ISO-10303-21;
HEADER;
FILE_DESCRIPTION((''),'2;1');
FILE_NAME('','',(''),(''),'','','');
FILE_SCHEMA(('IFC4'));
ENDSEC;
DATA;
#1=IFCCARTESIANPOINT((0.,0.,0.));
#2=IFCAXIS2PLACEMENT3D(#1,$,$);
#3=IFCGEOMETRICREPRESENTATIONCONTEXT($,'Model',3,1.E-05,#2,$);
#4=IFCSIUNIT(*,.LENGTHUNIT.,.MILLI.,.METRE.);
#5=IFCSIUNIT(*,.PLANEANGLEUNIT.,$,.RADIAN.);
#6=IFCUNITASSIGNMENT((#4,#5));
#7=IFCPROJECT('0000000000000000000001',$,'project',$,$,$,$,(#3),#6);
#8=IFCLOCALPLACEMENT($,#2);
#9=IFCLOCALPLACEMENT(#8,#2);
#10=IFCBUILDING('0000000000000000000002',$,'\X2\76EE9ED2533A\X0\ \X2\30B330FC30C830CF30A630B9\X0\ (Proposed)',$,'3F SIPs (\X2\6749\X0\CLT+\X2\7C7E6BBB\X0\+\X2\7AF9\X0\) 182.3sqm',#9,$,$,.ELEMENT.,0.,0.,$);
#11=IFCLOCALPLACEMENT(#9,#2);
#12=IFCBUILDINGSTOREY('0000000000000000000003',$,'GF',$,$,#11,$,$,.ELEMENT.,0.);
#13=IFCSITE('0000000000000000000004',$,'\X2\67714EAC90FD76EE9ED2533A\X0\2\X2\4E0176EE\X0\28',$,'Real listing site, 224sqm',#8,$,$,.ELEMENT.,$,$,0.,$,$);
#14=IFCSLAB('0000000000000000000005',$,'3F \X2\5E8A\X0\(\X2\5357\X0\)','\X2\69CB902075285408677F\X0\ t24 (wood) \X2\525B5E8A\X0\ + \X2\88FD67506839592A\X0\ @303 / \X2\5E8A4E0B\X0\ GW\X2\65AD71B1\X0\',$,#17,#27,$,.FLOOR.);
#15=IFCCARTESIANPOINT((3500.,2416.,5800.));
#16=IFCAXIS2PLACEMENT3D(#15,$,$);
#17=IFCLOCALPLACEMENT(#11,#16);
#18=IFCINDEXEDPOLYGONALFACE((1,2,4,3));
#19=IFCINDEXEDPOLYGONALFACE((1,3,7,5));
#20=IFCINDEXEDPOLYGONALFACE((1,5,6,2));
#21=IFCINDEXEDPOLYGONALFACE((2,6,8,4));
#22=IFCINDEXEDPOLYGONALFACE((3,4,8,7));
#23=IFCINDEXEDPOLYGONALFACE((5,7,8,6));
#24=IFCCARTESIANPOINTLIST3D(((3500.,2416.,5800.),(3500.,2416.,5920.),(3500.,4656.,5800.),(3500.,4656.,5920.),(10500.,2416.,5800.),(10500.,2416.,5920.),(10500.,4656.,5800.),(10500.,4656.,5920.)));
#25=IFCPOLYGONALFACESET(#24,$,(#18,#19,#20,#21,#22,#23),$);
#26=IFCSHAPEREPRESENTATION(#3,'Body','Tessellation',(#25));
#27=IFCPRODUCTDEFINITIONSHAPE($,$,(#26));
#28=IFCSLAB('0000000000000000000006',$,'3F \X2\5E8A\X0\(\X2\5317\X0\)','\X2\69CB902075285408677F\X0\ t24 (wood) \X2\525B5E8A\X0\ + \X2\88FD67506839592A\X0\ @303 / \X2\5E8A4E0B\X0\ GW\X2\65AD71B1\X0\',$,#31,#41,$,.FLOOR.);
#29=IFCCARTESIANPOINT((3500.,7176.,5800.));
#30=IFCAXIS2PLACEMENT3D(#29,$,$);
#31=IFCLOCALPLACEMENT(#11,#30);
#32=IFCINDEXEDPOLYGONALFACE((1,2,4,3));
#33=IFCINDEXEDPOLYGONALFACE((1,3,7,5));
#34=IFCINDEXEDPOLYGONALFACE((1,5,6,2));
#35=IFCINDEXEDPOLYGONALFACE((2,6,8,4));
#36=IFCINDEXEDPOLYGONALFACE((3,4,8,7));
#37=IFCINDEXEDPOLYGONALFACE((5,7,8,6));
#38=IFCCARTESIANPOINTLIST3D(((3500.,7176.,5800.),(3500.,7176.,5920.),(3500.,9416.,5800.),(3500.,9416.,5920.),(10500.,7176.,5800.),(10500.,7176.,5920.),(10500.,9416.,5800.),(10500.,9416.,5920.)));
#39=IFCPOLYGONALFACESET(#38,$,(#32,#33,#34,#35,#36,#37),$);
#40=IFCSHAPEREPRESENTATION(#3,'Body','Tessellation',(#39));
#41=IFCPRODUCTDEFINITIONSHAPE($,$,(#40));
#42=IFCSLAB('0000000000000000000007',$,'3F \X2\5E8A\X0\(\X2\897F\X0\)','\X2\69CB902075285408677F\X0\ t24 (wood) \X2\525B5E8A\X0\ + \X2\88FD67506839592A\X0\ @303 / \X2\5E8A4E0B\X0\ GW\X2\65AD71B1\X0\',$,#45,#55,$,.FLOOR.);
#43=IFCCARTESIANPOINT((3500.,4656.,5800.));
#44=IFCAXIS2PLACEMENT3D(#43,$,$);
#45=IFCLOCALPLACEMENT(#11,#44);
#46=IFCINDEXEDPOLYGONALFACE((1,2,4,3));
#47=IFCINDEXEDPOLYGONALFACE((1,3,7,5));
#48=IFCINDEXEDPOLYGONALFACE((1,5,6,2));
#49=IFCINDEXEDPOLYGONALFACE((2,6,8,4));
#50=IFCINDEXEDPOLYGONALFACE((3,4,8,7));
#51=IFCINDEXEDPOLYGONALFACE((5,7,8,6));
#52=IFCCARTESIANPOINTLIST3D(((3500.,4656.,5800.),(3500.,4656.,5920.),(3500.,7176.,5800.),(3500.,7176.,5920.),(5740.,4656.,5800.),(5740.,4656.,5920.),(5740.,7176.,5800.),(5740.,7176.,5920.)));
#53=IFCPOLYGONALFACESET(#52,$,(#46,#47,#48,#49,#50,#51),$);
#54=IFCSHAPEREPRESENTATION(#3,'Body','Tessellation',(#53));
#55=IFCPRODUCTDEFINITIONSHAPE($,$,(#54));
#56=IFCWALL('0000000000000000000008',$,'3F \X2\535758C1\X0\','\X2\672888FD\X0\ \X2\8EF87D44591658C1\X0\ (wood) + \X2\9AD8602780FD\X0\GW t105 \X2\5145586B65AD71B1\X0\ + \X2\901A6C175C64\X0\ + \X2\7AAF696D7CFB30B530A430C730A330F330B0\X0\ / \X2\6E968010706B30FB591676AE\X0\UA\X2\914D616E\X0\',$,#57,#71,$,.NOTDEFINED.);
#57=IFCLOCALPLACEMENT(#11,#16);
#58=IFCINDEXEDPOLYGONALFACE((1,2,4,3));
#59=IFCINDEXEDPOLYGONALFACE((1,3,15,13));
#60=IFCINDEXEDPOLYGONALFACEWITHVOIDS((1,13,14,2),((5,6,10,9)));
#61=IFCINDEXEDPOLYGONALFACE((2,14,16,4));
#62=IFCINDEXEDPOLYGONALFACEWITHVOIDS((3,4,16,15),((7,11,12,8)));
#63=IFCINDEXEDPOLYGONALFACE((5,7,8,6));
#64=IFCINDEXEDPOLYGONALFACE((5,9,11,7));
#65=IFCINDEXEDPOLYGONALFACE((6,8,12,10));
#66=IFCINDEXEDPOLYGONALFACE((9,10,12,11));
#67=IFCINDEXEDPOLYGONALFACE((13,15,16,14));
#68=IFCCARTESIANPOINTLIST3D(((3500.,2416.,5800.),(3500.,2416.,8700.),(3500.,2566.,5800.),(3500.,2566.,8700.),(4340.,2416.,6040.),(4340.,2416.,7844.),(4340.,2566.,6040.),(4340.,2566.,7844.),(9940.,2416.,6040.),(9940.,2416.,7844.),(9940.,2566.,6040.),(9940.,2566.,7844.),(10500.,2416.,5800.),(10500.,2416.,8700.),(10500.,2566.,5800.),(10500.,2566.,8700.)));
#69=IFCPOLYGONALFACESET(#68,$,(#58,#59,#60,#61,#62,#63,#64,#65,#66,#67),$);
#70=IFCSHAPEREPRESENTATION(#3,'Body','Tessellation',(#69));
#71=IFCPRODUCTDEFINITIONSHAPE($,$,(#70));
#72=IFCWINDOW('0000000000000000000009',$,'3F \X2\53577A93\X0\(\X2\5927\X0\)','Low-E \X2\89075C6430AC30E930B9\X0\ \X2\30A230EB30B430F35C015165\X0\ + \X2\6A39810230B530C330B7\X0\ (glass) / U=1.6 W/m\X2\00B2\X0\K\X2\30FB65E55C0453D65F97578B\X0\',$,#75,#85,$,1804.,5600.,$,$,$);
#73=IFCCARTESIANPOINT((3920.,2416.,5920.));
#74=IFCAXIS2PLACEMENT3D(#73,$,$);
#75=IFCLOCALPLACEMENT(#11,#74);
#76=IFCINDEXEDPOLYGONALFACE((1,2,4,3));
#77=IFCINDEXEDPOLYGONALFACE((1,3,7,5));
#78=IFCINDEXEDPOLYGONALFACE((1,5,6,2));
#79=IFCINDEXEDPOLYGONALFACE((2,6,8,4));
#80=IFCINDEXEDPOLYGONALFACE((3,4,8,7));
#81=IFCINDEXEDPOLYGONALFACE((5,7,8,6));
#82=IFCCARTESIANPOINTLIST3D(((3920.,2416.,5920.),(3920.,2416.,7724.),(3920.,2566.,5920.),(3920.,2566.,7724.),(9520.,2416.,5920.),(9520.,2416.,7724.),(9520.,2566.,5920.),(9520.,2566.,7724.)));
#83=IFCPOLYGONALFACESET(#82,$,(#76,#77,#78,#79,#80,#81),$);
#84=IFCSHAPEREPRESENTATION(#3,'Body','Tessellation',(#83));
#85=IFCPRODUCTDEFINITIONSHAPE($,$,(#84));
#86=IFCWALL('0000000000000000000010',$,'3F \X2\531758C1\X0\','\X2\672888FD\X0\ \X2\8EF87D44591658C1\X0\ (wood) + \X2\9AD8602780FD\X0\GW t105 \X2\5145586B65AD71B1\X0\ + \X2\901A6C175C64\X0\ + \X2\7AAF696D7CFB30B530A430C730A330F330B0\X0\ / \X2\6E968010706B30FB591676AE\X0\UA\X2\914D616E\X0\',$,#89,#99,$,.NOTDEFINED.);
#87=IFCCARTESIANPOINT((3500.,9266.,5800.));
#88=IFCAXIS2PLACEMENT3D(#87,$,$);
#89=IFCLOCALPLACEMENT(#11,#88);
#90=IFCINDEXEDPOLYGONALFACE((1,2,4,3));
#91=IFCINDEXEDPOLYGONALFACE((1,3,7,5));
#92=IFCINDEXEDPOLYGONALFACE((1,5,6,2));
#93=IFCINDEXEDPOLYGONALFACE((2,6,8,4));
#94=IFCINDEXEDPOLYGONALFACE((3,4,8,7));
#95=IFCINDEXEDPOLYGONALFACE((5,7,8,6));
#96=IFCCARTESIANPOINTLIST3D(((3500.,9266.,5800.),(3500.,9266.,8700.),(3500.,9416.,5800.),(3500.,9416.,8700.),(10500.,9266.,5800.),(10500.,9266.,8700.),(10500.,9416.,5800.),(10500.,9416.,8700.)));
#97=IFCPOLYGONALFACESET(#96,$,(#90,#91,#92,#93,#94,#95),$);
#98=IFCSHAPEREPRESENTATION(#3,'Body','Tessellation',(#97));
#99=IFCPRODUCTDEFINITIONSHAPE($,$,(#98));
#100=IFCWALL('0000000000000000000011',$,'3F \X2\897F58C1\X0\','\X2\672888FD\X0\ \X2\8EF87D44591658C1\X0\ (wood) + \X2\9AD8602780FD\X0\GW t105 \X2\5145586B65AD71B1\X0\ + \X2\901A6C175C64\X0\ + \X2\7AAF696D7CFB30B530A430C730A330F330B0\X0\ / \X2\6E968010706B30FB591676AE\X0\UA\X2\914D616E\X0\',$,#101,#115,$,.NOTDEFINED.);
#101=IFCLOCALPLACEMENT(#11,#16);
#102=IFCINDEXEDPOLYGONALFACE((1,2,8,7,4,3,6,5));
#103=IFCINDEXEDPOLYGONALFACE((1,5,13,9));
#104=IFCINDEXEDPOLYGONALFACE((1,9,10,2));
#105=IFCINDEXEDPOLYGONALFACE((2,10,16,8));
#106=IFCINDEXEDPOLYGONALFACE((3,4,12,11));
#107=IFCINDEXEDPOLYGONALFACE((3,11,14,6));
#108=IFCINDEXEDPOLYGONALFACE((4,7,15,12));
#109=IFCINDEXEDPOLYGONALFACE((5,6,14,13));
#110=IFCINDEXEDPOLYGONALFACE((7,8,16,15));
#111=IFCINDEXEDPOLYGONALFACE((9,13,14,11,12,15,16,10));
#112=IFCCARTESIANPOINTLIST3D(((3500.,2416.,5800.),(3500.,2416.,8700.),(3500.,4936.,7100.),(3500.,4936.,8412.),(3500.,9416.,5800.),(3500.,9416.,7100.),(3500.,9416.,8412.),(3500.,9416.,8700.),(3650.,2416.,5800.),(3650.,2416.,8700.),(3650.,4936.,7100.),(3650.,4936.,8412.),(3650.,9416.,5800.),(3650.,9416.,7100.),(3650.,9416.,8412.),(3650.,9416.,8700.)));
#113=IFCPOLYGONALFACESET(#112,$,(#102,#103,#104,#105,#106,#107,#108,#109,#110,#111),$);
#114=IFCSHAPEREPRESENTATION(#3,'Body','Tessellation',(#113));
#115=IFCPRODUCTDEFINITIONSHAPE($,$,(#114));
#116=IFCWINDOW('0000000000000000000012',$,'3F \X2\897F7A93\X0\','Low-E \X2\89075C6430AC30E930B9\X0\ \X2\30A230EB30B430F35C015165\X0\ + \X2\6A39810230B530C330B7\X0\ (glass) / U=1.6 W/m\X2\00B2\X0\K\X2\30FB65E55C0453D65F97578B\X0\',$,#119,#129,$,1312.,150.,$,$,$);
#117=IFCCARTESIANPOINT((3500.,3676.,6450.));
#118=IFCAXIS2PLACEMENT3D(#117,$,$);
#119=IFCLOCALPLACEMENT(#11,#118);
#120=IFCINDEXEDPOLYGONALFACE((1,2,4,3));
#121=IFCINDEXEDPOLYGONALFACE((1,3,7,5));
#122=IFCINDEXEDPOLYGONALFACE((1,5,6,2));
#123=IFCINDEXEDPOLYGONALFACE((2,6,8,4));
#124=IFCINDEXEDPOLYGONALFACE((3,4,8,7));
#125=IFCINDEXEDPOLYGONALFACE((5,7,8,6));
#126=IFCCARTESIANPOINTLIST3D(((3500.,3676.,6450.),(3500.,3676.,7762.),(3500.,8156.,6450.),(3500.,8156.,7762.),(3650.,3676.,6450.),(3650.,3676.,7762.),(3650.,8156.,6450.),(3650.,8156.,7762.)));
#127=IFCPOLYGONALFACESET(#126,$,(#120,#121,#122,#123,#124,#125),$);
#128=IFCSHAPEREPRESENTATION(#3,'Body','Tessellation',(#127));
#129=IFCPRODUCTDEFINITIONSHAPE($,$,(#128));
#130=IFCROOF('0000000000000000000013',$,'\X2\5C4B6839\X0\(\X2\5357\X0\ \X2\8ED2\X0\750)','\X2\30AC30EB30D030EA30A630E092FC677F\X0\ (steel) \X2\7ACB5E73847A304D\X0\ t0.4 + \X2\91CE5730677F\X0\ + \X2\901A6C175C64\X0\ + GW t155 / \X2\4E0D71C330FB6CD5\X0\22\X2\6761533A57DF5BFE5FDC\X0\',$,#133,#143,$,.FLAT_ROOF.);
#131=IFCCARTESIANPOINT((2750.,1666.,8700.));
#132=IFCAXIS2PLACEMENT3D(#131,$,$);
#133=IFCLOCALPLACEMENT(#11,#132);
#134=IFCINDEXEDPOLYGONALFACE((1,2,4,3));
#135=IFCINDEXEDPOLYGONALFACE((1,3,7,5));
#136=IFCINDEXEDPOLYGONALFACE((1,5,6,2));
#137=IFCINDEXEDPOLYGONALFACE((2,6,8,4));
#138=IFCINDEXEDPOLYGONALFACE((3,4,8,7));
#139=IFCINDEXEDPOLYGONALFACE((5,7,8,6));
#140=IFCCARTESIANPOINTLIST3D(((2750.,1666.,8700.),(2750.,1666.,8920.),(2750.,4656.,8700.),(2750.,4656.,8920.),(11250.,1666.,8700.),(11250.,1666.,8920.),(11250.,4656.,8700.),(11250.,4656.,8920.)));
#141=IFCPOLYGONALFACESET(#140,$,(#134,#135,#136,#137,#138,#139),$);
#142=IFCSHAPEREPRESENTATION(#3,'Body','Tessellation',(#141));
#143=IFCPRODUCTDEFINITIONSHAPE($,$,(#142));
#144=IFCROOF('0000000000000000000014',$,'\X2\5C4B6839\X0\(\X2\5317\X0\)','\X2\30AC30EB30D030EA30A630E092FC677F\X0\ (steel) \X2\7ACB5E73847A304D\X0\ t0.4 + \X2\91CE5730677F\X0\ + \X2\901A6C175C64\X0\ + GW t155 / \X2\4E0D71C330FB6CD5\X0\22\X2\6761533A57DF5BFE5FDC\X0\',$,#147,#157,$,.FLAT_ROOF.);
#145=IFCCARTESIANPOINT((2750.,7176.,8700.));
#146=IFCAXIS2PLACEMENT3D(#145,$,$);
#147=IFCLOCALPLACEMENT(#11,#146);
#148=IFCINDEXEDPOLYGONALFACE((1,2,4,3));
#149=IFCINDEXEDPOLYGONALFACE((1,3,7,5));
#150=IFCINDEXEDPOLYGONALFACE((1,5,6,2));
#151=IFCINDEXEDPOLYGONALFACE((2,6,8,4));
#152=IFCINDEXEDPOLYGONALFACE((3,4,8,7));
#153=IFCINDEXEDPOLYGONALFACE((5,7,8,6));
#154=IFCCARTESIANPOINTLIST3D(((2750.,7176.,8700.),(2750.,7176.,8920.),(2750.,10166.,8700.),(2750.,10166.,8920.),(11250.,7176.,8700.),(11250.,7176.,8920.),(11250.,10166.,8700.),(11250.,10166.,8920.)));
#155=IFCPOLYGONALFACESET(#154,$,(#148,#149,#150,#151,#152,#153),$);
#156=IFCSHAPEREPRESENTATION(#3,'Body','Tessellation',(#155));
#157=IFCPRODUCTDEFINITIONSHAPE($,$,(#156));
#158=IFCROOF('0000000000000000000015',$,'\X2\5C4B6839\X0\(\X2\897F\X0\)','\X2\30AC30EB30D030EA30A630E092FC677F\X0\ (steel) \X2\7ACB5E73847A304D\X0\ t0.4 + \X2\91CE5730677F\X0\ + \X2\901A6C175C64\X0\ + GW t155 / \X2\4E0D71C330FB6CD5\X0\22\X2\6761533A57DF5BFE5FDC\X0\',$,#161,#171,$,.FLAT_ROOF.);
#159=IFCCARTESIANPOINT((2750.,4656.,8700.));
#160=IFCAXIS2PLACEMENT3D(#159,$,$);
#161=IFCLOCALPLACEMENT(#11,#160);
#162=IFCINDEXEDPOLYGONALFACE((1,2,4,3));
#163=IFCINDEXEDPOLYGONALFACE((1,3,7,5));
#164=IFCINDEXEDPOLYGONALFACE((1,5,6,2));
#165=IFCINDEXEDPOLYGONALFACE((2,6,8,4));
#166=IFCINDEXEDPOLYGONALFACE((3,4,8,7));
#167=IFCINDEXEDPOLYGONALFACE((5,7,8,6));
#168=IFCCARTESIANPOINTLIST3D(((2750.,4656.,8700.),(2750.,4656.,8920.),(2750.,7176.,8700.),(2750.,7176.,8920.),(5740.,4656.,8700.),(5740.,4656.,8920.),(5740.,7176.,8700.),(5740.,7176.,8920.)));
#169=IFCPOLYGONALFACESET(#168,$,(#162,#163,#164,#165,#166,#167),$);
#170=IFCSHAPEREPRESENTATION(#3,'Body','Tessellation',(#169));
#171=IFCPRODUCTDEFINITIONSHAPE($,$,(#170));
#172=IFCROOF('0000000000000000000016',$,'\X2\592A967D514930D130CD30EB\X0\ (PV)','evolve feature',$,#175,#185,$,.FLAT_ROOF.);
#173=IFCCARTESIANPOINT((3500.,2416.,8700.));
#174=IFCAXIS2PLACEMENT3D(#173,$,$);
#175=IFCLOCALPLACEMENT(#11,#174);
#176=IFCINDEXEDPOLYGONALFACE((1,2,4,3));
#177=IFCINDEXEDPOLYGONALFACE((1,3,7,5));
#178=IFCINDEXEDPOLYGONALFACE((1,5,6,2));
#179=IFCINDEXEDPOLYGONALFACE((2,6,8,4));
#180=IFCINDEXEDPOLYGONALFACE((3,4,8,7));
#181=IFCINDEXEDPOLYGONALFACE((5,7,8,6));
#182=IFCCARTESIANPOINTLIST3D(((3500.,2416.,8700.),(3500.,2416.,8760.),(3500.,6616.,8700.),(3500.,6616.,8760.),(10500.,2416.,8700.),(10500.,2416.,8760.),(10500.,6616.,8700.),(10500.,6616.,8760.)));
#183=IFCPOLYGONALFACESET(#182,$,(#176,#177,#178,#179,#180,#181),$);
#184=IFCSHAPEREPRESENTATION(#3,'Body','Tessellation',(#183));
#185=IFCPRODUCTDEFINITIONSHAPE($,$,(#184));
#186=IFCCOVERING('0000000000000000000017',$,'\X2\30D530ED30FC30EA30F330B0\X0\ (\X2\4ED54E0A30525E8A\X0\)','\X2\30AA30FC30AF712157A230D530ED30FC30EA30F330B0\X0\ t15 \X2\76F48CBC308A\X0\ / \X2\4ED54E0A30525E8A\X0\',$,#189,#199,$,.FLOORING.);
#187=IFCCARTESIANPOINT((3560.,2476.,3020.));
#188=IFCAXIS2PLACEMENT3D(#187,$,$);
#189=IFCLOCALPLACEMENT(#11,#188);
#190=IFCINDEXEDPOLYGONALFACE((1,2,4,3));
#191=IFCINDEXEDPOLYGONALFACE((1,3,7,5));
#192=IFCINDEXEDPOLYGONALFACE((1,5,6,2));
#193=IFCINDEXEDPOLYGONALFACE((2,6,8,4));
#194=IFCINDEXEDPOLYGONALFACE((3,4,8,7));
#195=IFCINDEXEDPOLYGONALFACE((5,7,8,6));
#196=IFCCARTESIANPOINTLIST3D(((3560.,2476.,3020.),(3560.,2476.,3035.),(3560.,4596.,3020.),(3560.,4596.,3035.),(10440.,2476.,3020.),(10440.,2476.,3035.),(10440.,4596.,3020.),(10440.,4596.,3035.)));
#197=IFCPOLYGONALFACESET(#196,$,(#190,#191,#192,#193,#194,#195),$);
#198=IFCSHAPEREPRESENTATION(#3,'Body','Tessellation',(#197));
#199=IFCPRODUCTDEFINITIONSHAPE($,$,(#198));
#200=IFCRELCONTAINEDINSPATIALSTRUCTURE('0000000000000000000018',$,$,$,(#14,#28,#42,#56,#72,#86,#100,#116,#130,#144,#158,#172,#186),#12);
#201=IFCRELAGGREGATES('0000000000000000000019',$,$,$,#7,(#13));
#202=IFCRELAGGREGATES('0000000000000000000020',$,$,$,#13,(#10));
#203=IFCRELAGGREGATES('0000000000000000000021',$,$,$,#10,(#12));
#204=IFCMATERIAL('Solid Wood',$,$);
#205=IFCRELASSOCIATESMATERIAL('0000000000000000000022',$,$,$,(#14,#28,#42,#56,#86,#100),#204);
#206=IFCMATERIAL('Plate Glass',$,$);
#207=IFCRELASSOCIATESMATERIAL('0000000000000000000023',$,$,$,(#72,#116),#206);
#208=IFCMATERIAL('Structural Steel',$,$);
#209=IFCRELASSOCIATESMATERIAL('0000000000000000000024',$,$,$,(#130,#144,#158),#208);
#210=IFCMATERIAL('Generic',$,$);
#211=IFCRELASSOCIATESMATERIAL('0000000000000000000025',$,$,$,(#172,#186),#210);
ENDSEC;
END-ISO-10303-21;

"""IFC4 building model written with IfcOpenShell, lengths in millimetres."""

from ifc_helpers import new_model, si_unit, frame, frame_2d, origin, place, context, project, spatial, rectangle, extrude, material, element, fill, save


model = new_model("IFC4")

# Units and contexts
model_context = context("Model", 3, precision=1e-05, world=origin())
ifc_project = project(units=[si_unit("LENGTHUNIT", "METRE", prefix="MILLI"), si_unit("PLANEANGLEUNIT", "RADIAN")], contexts=[model_context])

# Site, building, storey
site_placement = place(None, origin())
site = spatial("IfcSite", under=ifc_project, at=site_placement, Name="東京都目黒区2丁目28", ObjectType="Real listing site, 224sqm", CompositionType="ELEMENT", RefElevation=0.0)
building_placement = place(site_placement, origin())
building = spatial("IfcBuilding", under=site, at=building_placement, Name="目黒区 コートハウス (Proposed)", ObjectType="3F SIPs (杉CLT+籾殻+竹) 182.3sqm", CompositionType="ELEMENT", ElevationOfRefHeight=0.0, ElevationOfTerrain=0.0)
storey_placement = place(building_placement, origin())
storey = spatial("IfcBuildingStorey", under=building, at=storey_placement, Name="GF", CompositionType="ELEMENT", Elevation=0.0)

# Slabs
ifc_material_1 = material(Name="Solid Wood")
slab_1_placement = place(storey_placement, frame((3500.0, 2416.0, 5800.0)))
element("IfcSlab", 1, at=slab_1_placement, inside=storey, material=ifc_material_1, Name="3F 床(南)", Description="構造用合板 t24 (wood) 剛床 + 製材根太 @303 / 床下 GW断熱", PredefinedType="FLOOR", context=model_context, shape_type="SweptSolid", body=[
    extrude(rectangle(XDim=7000.0, YDim=2240.0, at=frame_2d((3500.0, 1120.0))), frame((3500.0, 2416.0, 5800.0)), (0.0, 0.0, 1.0), 120.0),
])
slab_2_placement = place(storey_placement, frame((3500.0, 7176.0, 5800.0)))
element("IfcSlab", 2, at=slab_2_placement, inside=storey, material=ifc_material_1, Name="3F 床(北)", Description="構造用合板 t24 (wood) 剛床 + 製材根太 @303 / 床下 GW断熱", PredefinedType="FLOOR", context=model_context, shape_type="SweptSolid", body=[
    extrude(rectangle(XDim=7000.0, YDim=2240.0, at=frame_2d((3500.0, 1120.0))), frame((3500.0, 7176.0, 5800.0)), (0.0, 0.0, 1.0), 120.0),
])
slab_3_placement = place(storey_placement, frame((3500.0, 4656.0, 5800.0)))
element("IfcSlab", 3, at=slab_3_placement, inside=storey, material=ifc_material_1, Name="3F 床(西)", Description="構造用合板 t24 (wood) 剛床 + 製材根太 @303 / 床下 GW断熱", PredefinedType="FLOOR", context=model_context, shape_type="SweptSolid", body=[
    extrude(rectangle(XDim=2240.0, YDim=2520.0, at=frame_2d((1120.0, 1260.0))), frame((3500.0, 4656.0, 5800.0)), (0.0, 0.0, 1.0), 120.0),
])

# Wall, opening, window
wall_1_placement = place(storey_placement, frame((3500.0, 2416.0, 5800.0)))
wall_1 = element("IfcWall", 4, at=wall_1_placement, inside=storey, material=ifc_material_1, Name="3F 南壁", Description="木製 軸組外壁 (wood) + 高性能GW t105 充填断熱 + 通気層 + 窯業系サイディング / 準耐火・外皮UA配慮", PredefinedType="NOTDEFINED", context=model_context, shape_type="SweptSolid", body=[
    extrude(rectangle(XDim=7000.0, YDim=150.0, at=frame_2d((3500.0, 75.0))), frame((3500.0, 2416.0, 5800.0)), (0.0, 0.0, 1.0), 2900.0),
])
opening_1_placement = place(storey_placement, frame((3920.0, 2416.0, 5920.0)))
opening_1 = element("IfcOpeningElement", 5, at=opening_1_placement, cuts=wall_1, PredefinedType="NOTDEFINED", context=model_context, shape_type="SweptSolid", body=[
    extrude(rectangle(XDim=5600.0, YDim=150.0, at=frame_2d((2800.0, 75.0))), frame((3920.0, 2416.0, 5920.0)), (0.0, 0.0, 1.0), 1804.0),
])
ifc_material_2 = material(Name="Plate Glass")
window_1_placement = place(storey_placement, frame((3920.0, 2416.0, 5920.0)))
window_1 = element("IfcWindow", 6, at=window_1_placement, inside=storey, material=ifc_material_2, Name="3F 南窓(大)", Description="Low-E 複層ガラス アルゴン封入 + 樹脂サッシ (glass) / U=1.6 W/m²K・日射取得型", OverallHeight=1804.0, OverallWidth=5600.0, context=model_context, shape_type="SweptSolid", body=[
    extrude(rectangle(XDim=5600.0, YDim=150.0, at=frame_2d((2800.0, 75.0))), frame((3920.0, 2416.0, 5920.0)), (0.0, 0.0, 1.0), 1804.0),
])
fill(opening_1, window_1)

# Wall
wall_2_placement = place(storey_placement, frame((3500.0, 9266.0, 5800.0)))
element("IfcWall", 7, at=wall_2_placement, inside=storey, material=ifc_material_1, Name="3F 北壁", Description="木製 軸組外壁 (wood) + 高性能GW t105 充填断熱 + 通気層 + 窯業系サイディング / 準耐火・外皮UA配慮", PredefinedType="NOTDEFINED", context=model_context, shape_type="SweptSolid", body=[
    extrude(rectangle(XDim=7000.0, YDim=150.0, at=frame_2d((3500.0, 75.0))), frame((3500.0, 9266.0, 5800.0)), (0.0, 0.0, 1.0), 2900.0),
])

# Wall, opening, window
wall_3_placement = place(storey_placement, frame((3500.0, 2416.0, 5800.0)))
wall_3 = element("IfcWall", 8, at=wall_3_placement, inside=storey, material=ifc_material_1, Name="3F 西壁", Description="木製 軸組外壁 (wood) + 高性能GW t105 充填断熱 + 通気層 + 窯業系サイディング / 準耐火・外皮UA配慮", PredefinedType="NOTDEFINED", context=model_context, shape_type="SweptSolid", body=[
    extrude(rectangle(XDim=150.0, YDim=7000.0, at=frame_2d((75.0, 3500.0))), frame((3500.0, 2416.0, 5800.0)), (0.0, 0.0, 1.0), 2900.0),
])
opening_2_placement = place(storey_placement, frame((3500.0, 3676.0, 6450.0)))
opening_2 = element("IfcOpeningElement", 9, at=opening_2_placement, cuts=wall_3, PredefinedType="NOTDEFINED", context=model_context, shape_type="SweptSolid", body=[
    extrude(rectangle(XDim=150.0, YDim=4480.0, at=frame_2d((75.0, 2240.0))), frame((3500.0, 3676.0, 6450.0)), (0.0, 0.0, 1.0), 1312.0),
])
window_2_placement = place(storey_placement, frame((3500.0, 3676.0, 6450.0)))
window_2 = element("IfcWindow", 10, at=window_2_placement, inside=storey, material=ifc_material_2, Name="3F 西窓", Description="Low-E 複層ガラス アルゴン封入 + 樹脂サッシ (glass) / U=1.6 W/m²K・日射取得型", OverallHeight=1312.0, OverallWidth=150.0, context=model_context, shape_type="SweptSolid", body=[
    extrude(rectangle(XDim=150.0, YDim=4480.0, at=frame_2d((75.0, 2240.0))), frame((3500.0, 3676.0, 6450.0)), (0.0, 0.0, 1.0), 1312.0),
])
fill(opening_2, window_2)

# Roofs
ifc_material_3 = material(Name="Structural Steel")
roof_1_placement = place(storey_placement, frame((2750.0, 1666.0, 8700.0)))
element("IfcRoof", 11, at=roof_1_placement, inside=storey, material=ifc_material_3, Name="屋根(南 軒750)", Description="ガルバリウム鋼板 (steel) 立平葺き t0.4 + 野地板 + 通気層 + GW t155 / 不燃・法22条区域対応", PredefinedType="FLAT_ROOF", context=model_context, shape_type="SweptSolid", body=[
    extrude(rectangle(XDim=8500.0, YDim=2990.0, at=frame_2d((4250.0, 1495.0))), frame((2750.0, 1666.0, 8700.0)), (0.0, 0.0, 1.0), 220.0),
])
roof_2_placement = place(storey_placement, frame((2750.0, 7176.0, 8700.0)))
element("IfcRoof", 12, at=roof_2_placement, inside=storey, material=ifc_material_3, Name="屋根(北)", Description="ガルバリウム鋼板 (steel) 立平葺き t0.4 + 野地板 + 通気層 + GW t155 / 不燃・法22条区域対応", PredefinedType="FLAT_ROOF", context=model_context, shape_type="SweptSolid", body=[
    extrude(rectangle(XDim=8500.0, YDim=2990.0, at=frame_2d((4250.0, 1495.0))), frame((2750.0, 7176.0, 8700.0)), (0.0, 0.0, 1.0), 220.0),
])
roof_3_placement = place(storey_placement, frame((2750.0, 4656.0, 8700.0)))
element("IfcRoof", 13, at=roof_3_placement, inside=storey, material=ifc_material_3, Name="屋根(西)", Description="ガルバリウム鋼板 (steel) 立平葺き t0.4 + 野地板 + 通気層 + GW t155 / 不燃・法22条区域対応", PredefinedType="FLAT_ROOF", context=model_context, shape_type="SweptSolid", body=[
    extrude(rectangle(XDim=2990.0, YDim=2520.0, at=frame_2d((1495.0, 1260.0))), frame((2750.0, 4656.0, 8700.0)), (0.0, 0.0, 1.0), 220.0),
])
ifc_material_4 = material(Name="Generic")
roof_4_placement = place(storey_placement, frame((3500.0, 2416.0, 8700.0)))
element("IfcRoof", 14, at=roof_4_placement, inside=storey, material=ifc_material_4, Name="太陽光パネル (PV)", Description="evolve feature", PredefinedType="FLAT_ROOF", context=model_context, shape_type="SweptSolid", body=[
    extrude(rectangle(XDim=7000.0, YDim=4200.0, at=frame_2d((3500.0, 2100.0))), frame((3500.0, 2416.0, 8700.0)), (0.0, 0.0, 1.0), 60.0),
])

# Covering
covering_1_placement = place(storey_placement, frame((3560.0, 2476.0, 3020.0)))
element("IfcCovering", 15, at=covering_1_placement, inside=storey, material=ifc_material_4, Name="フローリング (仕上げ床)", Description="オーク無垢フローリング t15 直貼り / 仕上げ床", PredefinedType="FLOORING", context=model_context, shape_type="SweptSolid", body=[
    extrude(rectangle(XDim=6880.0, YDim=2120.0, at=frame_2d((3440.0, 1060.0))), frame((3560.0, 2476.0, 3020.0)), (0.0, 0.0, 1.0), 15.0),
])

save(model, "model.ifc")
